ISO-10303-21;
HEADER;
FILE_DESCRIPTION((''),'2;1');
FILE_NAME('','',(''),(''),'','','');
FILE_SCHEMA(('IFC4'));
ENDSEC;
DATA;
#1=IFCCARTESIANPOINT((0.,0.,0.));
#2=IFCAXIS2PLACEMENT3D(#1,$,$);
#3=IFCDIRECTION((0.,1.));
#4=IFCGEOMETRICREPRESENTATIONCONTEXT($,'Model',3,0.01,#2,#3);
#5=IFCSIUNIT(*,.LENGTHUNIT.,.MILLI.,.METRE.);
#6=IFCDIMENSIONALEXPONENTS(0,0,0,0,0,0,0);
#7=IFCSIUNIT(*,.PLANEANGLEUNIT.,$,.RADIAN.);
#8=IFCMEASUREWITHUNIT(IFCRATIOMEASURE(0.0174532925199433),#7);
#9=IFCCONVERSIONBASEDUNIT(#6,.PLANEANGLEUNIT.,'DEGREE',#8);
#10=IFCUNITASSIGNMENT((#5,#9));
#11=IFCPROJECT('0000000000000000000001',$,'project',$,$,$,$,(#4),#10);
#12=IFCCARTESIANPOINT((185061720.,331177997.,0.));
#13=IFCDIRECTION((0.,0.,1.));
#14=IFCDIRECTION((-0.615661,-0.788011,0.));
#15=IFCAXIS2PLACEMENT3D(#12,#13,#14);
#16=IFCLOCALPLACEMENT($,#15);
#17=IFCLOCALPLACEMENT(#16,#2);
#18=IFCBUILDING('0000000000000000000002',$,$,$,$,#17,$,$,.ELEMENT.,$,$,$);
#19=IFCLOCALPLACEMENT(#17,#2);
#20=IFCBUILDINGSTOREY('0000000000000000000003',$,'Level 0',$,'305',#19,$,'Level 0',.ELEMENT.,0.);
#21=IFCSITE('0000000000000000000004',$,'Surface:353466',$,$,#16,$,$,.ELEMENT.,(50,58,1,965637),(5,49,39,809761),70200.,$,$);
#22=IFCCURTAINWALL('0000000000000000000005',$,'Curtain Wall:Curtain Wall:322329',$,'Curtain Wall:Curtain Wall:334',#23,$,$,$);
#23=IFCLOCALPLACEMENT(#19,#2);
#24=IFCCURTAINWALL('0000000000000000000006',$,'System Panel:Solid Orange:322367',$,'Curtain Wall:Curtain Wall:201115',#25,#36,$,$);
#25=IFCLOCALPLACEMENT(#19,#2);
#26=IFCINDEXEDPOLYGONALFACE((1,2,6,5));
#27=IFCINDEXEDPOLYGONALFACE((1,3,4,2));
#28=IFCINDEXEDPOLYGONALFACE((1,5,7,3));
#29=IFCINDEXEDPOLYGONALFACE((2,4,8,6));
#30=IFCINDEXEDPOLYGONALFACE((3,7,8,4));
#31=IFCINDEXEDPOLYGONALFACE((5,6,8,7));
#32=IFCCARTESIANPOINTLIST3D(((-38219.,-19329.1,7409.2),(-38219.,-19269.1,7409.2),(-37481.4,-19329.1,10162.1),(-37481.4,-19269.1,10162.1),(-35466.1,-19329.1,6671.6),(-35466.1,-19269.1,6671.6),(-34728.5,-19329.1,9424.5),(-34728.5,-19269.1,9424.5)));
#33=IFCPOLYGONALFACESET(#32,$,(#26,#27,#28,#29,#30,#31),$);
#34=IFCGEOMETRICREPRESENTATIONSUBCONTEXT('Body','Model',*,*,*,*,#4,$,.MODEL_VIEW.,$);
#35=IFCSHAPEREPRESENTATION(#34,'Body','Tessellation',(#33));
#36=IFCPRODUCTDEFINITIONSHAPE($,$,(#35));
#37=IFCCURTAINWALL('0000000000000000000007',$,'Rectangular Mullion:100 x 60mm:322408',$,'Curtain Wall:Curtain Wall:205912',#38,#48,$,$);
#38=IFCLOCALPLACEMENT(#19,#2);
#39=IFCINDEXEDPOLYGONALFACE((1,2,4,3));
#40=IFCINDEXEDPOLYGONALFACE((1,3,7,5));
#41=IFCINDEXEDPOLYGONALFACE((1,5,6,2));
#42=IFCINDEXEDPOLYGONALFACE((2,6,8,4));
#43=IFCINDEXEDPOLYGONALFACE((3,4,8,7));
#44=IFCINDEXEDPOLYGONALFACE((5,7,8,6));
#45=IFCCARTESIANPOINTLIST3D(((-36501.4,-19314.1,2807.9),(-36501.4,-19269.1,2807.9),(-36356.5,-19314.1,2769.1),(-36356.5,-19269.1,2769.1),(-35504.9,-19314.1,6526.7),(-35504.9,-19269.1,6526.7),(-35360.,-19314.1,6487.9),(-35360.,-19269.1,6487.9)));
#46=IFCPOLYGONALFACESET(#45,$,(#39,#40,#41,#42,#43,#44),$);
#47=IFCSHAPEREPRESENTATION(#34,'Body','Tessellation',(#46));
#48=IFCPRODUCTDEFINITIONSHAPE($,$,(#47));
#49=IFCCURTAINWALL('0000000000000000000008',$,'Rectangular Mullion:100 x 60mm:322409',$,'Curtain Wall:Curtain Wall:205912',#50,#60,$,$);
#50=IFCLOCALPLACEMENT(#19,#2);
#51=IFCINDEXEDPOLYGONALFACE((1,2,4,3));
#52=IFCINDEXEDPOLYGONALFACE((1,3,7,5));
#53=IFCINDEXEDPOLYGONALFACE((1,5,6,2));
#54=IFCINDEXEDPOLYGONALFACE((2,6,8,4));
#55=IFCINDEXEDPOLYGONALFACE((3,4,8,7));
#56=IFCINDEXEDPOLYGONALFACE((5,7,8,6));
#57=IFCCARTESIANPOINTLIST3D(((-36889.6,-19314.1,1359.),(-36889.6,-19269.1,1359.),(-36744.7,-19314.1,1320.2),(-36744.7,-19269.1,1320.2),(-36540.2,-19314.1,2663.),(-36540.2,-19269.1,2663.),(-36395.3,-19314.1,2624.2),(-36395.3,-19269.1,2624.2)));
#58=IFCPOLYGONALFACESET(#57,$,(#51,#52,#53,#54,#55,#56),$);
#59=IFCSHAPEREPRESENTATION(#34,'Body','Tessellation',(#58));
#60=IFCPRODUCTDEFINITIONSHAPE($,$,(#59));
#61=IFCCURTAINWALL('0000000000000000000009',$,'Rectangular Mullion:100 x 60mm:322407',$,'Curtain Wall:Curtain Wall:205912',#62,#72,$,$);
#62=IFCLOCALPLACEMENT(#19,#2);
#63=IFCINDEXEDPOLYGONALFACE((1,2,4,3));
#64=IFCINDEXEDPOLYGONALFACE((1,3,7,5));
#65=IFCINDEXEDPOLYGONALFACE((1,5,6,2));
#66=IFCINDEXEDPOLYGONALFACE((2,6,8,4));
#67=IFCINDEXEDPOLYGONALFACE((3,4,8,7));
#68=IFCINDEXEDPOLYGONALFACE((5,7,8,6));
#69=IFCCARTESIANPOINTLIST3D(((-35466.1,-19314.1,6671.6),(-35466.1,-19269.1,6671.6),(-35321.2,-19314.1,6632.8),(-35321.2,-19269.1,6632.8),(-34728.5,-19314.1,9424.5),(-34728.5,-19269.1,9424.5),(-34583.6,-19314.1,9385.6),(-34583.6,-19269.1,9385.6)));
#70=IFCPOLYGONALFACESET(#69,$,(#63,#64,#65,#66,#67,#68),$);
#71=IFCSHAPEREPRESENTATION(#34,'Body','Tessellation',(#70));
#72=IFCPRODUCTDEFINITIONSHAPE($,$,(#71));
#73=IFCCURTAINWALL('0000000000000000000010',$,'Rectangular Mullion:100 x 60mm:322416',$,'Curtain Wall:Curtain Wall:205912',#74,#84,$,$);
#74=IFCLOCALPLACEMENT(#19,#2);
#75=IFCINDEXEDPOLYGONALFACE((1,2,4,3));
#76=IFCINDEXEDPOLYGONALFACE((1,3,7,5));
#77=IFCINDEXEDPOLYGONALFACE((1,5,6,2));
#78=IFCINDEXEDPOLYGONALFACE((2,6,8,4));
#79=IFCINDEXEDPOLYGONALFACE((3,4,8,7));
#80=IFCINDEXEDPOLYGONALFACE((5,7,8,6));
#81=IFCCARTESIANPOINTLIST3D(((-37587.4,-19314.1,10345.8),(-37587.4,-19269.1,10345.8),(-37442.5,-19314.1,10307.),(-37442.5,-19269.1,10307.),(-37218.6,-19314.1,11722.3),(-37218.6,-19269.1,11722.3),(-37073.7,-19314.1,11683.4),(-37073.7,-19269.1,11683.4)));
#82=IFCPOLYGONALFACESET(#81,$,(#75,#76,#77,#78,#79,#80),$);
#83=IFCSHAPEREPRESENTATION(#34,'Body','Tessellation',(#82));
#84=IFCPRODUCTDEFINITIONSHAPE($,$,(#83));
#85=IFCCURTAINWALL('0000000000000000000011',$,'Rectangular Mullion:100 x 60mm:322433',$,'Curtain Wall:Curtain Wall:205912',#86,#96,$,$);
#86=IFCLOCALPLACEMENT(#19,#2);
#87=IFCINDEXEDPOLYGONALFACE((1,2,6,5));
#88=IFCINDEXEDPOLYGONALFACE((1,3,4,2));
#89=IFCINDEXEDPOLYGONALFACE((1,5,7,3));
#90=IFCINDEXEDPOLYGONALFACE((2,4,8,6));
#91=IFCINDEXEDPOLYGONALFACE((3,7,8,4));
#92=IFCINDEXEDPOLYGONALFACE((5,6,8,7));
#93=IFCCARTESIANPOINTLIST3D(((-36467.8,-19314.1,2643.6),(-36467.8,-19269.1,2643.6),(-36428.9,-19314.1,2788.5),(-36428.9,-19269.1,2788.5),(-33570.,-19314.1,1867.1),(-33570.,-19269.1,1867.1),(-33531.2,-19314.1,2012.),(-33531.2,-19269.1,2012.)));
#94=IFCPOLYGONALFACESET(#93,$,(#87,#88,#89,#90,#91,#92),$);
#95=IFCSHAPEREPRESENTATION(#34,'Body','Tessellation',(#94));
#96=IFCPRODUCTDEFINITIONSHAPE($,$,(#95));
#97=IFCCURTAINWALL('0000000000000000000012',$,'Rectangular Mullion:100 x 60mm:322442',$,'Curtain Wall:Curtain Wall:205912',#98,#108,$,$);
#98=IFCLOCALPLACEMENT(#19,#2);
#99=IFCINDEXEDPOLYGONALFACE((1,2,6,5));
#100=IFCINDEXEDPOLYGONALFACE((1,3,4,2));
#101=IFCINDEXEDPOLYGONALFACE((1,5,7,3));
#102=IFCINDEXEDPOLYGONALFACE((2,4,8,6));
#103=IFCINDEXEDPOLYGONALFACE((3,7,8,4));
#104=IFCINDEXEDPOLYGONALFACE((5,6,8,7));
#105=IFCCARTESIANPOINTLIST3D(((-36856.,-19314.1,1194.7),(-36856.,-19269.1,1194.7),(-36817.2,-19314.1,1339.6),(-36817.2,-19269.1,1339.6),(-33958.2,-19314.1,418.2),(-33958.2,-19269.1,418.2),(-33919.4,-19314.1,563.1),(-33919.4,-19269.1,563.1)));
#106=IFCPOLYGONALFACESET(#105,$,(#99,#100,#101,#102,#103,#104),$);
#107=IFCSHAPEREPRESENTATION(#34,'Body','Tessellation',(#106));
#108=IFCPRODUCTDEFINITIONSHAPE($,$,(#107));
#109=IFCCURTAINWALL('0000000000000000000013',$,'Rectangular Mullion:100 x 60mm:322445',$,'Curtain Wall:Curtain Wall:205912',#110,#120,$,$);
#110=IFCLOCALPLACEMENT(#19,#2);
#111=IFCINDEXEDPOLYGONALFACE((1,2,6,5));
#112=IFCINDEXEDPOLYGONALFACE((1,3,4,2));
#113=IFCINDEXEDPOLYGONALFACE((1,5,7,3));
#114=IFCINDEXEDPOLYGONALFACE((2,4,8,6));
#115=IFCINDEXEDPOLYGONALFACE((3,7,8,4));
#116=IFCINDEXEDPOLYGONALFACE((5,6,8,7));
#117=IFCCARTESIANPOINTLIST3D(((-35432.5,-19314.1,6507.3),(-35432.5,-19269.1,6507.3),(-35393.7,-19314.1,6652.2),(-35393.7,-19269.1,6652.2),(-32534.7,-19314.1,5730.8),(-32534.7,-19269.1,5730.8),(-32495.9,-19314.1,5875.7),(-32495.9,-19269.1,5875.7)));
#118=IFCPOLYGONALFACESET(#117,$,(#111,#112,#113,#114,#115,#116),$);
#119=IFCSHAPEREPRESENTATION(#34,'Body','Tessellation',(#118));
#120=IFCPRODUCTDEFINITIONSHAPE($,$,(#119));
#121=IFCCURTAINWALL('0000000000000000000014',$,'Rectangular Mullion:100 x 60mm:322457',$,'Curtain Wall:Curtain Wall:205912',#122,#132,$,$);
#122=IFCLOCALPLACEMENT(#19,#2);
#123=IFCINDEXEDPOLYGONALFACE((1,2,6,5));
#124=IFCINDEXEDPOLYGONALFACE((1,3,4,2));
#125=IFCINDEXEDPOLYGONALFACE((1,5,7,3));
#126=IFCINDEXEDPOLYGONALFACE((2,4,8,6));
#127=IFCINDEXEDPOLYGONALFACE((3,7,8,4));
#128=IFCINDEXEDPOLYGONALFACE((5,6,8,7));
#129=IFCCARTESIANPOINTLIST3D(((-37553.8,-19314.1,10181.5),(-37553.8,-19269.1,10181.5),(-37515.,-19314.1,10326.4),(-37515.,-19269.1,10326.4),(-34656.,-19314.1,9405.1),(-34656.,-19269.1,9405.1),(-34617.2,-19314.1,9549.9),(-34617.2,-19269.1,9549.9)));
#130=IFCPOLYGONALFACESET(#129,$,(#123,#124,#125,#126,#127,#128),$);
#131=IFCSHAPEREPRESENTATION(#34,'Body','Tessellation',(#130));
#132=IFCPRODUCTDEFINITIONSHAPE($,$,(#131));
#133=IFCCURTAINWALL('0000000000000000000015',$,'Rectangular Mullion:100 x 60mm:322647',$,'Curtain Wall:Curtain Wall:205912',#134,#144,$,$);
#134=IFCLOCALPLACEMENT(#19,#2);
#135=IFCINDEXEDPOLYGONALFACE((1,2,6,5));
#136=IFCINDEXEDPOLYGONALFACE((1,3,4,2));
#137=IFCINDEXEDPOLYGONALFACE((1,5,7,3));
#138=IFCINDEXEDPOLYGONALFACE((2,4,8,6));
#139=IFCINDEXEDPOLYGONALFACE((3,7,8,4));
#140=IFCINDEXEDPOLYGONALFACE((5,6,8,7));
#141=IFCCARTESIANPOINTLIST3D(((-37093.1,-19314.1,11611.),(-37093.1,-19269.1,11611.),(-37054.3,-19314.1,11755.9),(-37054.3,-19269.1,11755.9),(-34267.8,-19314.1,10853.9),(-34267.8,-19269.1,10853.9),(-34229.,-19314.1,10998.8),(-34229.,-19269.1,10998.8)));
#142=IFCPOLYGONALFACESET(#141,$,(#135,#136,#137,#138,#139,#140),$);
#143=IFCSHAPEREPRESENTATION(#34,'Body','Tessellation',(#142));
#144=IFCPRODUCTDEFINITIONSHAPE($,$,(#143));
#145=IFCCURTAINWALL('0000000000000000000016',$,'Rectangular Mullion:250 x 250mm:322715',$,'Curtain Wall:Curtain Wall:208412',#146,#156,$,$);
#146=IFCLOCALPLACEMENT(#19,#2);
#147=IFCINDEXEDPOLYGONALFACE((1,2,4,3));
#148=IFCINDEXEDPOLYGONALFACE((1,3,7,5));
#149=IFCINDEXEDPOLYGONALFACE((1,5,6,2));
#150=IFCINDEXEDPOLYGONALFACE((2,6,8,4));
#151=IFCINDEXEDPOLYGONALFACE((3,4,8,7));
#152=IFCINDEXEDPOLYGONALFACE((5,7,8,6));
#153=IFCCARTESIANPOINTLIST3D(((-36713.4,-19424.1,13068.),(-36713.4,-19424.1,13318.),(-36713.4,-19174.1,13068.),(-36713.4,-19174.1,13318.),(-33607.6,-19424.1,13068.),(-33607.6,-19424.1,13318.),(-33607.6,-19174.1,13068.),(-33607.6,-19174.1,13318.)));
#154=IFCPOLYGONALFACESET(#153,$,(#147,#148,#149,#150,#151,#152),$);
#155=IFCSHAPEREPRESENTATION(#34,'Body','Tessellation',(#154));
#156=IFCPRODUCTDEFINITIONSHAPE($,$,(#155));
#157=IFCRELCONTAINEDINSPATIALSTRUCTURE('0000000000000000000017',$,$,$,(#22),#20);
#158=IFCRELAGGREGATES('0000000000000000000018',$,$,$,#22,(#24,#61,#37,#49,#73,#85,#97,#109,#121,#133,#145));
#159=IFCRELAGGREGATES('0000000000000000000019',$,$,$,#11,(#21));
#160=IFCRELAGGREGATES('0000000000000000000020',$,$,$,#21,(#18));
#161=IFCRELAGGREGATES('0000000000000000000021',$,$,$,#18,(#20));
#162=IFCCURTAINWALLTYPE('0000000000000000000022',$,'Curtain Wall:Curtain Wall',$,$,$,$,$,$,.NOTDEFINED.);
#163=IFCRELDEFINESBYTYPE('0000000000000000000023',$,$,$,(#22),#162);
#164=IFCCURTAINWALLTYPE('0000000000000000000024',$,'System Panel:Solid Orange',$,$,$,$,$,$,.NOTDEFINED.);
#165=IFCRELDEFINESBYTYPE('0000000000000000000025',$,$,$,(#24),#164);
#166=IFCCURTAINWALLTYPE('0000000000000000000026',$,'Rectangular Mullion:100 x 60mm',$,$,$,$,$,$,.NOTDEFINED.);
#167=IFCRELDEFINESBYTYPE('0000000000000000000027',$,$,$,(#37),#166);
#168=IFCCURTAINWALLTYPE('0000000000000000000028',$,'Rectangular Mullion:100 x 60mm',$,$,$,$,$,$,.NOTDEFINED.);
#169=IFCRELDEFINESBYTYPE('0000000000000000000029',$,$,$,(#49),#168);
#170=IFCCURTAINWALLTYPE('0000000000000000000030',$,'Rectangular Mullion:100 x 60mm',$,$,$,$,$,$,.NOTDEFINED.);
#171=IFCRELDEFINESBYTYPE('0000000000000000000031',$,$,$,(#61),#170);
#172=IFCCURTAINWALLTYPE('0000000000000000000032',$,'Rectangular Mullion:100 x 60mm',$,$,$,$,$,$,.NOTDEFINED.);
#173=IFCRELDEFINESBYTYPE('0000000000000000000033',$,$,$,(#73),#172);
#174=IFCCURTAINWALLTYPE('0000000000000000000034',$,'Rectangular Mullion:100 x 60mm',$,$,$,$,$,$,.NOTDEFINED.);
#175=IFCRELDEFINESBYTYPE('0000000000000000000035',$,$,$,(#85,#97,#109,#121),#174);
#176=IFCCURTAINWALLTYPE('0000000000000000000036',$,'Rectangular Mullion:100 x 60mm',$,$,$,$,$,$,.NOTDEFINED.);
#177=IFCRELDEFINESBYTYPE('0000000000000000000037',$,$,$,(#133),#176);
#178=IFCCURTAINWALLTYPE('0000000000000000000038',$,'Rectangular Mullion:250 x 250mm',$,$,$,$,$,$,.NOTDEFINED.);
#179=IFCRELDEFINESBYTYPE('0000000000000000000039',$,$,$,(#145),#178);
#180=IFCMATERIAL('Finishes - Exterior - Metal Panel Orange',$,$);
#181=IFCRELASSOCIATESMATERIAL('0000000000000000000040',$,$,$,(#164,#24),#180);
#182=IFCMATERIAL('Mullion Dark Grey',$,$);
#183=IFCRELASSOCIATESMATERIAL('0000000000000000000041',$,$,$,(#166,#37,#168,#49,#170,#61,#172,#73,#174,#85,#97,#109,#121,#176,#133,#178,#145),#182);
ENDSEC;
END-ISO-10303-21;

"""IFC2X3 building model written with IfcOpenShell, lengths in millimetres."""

from ifc_helpers import new_model, entity, si_unit, converted_unit, direction, frame, frame_2d, origin, origin_2d_with_axis, place, context, subcontext, project, spatial, rectangle, extrude, source, transform, mapped, material, type_object, type_shapes, element, aggregate, save


model = new_model("IFC2X3")

# Units and contexts
model_context = context("Model", 3, precision=0.01, world=origin(), true_north=direction((0.0, 1.0)))
body_context = subcontext(model_context, "Body", "Model", "MODEL_VIEW")
ifc_project = project(units=[si_unit("LENGTHUNIT", "METRE", prefix="MILLI"), converted_unit("PLANEANGLEUNIT", "DEGREE", entity("IfcRatioMeasure", 0.0174532925199433), si_unit("PLANEANGLEUNIT", "RADIAN"), dimensions=[0, 0, 0, 0, 0, 0, 0])], contexts=[model_context])

# Site, building, storey
site_placement = place(None, frame((185061720.0, 331177997.0, 0.0), z_axis=(0.0, 0.0, 1.0), x_axis=(-0.615661, -0.788011, 0.0)))
site = spatial("IfcSite", under=ifc_project, at=site_placement, Name="Surface:353466", CompositionType="ELEMENT", RefLatitude=(50, 58, 1, 965637), RefLongitude=(5, 49, 39, 809761), RefElevation=70200.0)
building_placement = place(site_placement, origin())
building = spatial("IfcBuilding", under=site, at=building_placement, CompositionType="ELEMENT")
storey_placement = place(building_placement, origin())
storey = spatial("IfcBuildingStorey", under=building, at=storey_placement, Name="Level 0", ObjectType="305", LongName="Level 0", CompositionType="ELEMENT", Elevation=0.0)

# Curtain walls
curtain_wall_type_1 = type_object("IfcCurtainWallType", Name="Curtain Wall:Curtain Wall", PredefinedType="NOTDEFINED")
curtain_wall_1_placement = place(storey_placement, origin())
curtain_wall_1 = element("IfcCurtainWall", 1, at=curtain_wall_1_placement, inside=storey, type_object=curtain_wall_type_1, Name="Curtain Wall:Curtain Wall:322329", ObjectType="Curtain Wall:Curtain Wall:334")
ifc_material_1 = material(Name="Finishes - Exterior - Metal Panel Orange")
curtain_wall_type_2 = type_object("IfcCurtainWallType", Name="System Panel:Solid Orange", PredefinedType="NOTDEFINED", material=ifc_material_1)
shared_shape_1 = source(origin(), body_context, "Body", "SweptSolid", [
    extrude(rectangle(XDim=60.0, YDim=2850.0, at=frame_2d((0.0, 0.0), x_axis=(1.0, 0.0))), frame((0.0, 0.0, 0.0), z_axis=(0.0, 0.0, 1.0), x_axis=(0.0, 1.0, 0.0)), (0.0, 0.0, 1.0), 2850.0),
])
type_shapes(curtain_wall_type_2, [shared_shape_1])
curtain_wall_2_placement = place(storey_placement, frame((-36842.6, -19299.1, 7040.4), z_axis=(0.258819, 0.0, 0.965926), x_axis=(-0.965926, 0.0, 0.258819)))
curtain_wall_2 = element("IfcCurtainWall", 2, at=curtain_wall_2_placement, type_object=curtain_wall_type_2, material=ifc_material_1, Name="System Panel:Solid Orange:322367", ObjectType="Curtain Wall:Curtain Wall:201115", context=body_context, shape_type="MappedRepresentation", body=[
    mapped(shared_shape_1, transform((0.0, 0.0, 0.0), scale=1.0)),
])
ifc_material_2 = material(Name="Mullion Dark Grey")
curtain_wall_type_3 = type_object("IfcCurtainWallType", Name="Rectangular Mullion:100 x 60mm", PredefinedType="NOTDEFINED", material=ifc_material_2)
shared_shape_2 = source(origin(), body_context, "Body", "SweptSolid", [
    extrude(rectangle(XDim=45.0, YDim=150.0, at=frame_2d((0.0, 0.0), x_axis=(1.0, 0.0))), frame((0.0, 7.5, -3850.0), z_axis=(0.0, 0.0, 1.0), x_axis=(0.0, -1.0, 0.0)), (0.0, 0.0, 1.0), 3850.0),
])
type_shapes(curtain_wall_type_3, [shared_shape_2])
curtain_wall_3_placement = place(storey_placement, frame((-36428.9, -19299.1, 2788.5), z_axis=(-0.258819, 0.0, -0.965926), x_axis=(-0.965926, 0.0, 0.258819)))
curtain_wall_3 = element("IfcCurtainWall", 3, at=curtain_wall_3_placement, type_object=curtain_wall_type_3, material=ifc_material_2, Name="Rectangular Mullion:100 x 60mm:322408", ObjectType="Curtain Wall:Curtain Wall:205912", context=body_context, shape_type="MappedRepresentation", body=[
    mapped(shared_shape_2, transform((0.0, 0.0, 0.0), scale=1.0)),
])
curtain_wall_type_4 = type_object("IfcCurtainWallType", Name="Rectangular Mullion:100 x 60mm", PredefinedType="NOTDEFINED", material=ifc_material_2)
shared_shape_3 = source(origin(), body_context, "Body", "SweptSolid", [
    extrude(rectangle(XDim=45.0, YDim=150.0, at=frame_2d((0.0, 0.0), x_axis=(1.0, 0.0))), frame((0.0, 7.5, -1350.0), z_axis=(0.0, 0.0, 1.0), x_axis=(0.0, -1.0, 0.0)), (0.0, 0.0, 1.0), 1350.0),
])
type_shapes(curtain_wall_type_4, [shared_shape_3])
curtain_wall_4_placement = place(storey_placement, frame((-36817.2, -19299.1, 1339.6), z_axis=(-0.258819, 0.0, -0.965926), x_axis=(-0.965926, 0.0, 0.258819)))
curtain_wall_4 = element("IfcCurtainWall", 4, at=curtain_wall_4_placement, type_object=curtain_wall_type_4, material=ifc_material_2, Name="Rectangular Mullion:100 x 60mm:322409", ObjectType="Curtain Wall:Curtain Wall:205912", context=body_context, shape_type="MappedRepresentation", body=[
    mapped(shared_shape_3, transform((0.0, 0.0, 0.0), scale=1.0)),
])
curtain_wall_type_5 = type_object("IfcCurtainWallType", Name="Rectangular Mullion:100 x 60mm", PredefinedType="NOTDEFINED", material=ifc_material_2)
shared_shape_4 = source(origin(), body_context, "Body", "SweptSolid", [
    extrude(rectangle(XDim=45.0, YDim=150.0, at=frame_2d((0.0, 0.0), x_axis=(1.0, 0.0))), frame((0.0, 7.5, -2850.0), z_axis=(0.0, 0.0, 1.0), x_axis=(0.0, -1.0, 0.0)), (0.0, 0.0, 1.0), 2850.0),
])
type_shapes(curtain_wall_type_5, [shared_shape_4])
curtain_wall_5_placement = place(storey_placement, frame((-35393.7, -19299.1, 6652.2), z_axis=(-0.258819, 0.0, -0.965926), x_axis=(-0.965926, 0.0, 0.258819)))
curtain_wall_5 = element("IfcCurtainWall", 5, at=curtain_wall_5_placement, type_object=curtain_wall_type_5, material=ifc_material_2, Name="Rectangular Mullion:100 x 60mm:322407", ObjectType="Curtain Wall:Curtain Wall:205912", context=body_context, shape_type="MappedRepresentation", body=[
    mapped(shared_shape_4, transform((0.0, 0.0, 0.0), scale=1.0)),
])
curtain_wall_type_6 = type_object("IfcCurtainWallType", Name="Rectangular Mullion:100 x 60mm", PredefinedType="NOTDEFINED", material=ifc_material_2)
shared_shape_5 = source(origin(), body_context, "Body", "SweptSolid", [
    extrude(rectangle(XDim=45.0, YDim=150.0, at=frame_2d((0.0, 0.0), x_axis=(1.0, 0.0))), frame((0.0, 7.5, -1425.0), z_axis=(0.0, 0.0, 1.0), x_axis=(0.0, -1.0, 0.0)), (0.0, 0.0, 1.0), 1425.0),
])
type_shapes(curtain_wall_type_6, [shared_shape_5])
curtain_wall_6_placement = place(storey_placement, frame((-37515.0, -19299.1, 10326.4), z_axis=(-0.258819, 0.0, -0.965926), x_axis=(-0.965926, 0.0, 0.258819)))
curtain_wall_6 = element("IfcCurtainWall", 6, at=curtain_wall_6_placement, type_object=curtain_wall_type_6, material=ifc_material_2, Name="Rectangular Mullion:100 x 60mm:322416", ObjectType="Curtain Wall:Curtain Wall:205912", context=body_context, shape_type="MappedRepresentation", body=[
    mapped(shared_shape_5, transform((0.0, 0.0, 0.0), scale=1.0)),
])
curtain_wall_type_7 = type_object("IfcCurtainWallType", Name="Rectangular Mullion:100 x 60mm", PredefinedType="NOTDEFINED", material=ifc_material_2)
shared_shape_6 = source(origin(), body_context, "Body", "SweptSolid", [
    extrude(rectangle(XDim=45.0, YDim=150.0, at=frame_2d((0.0, 0.0), x_axis=(1.0, 0.0))), frame((0.0, 7.5, -3000.0), z_axis=(0.0, 0.0, 1.0), x_axis=(0.0, -1.0, 0.0)), (0.0, 0.0, 1.0), 3000.0),
])
type_shapes(curtain_wall_type_7, [shared_shape_6])
curtain_wall_7_placement = place(storey_placement, frame((-36448.4, -19299.1, 2716.0), z_axis=(-0.965926, 0.0, 0.258819), x_axis=(0.258819, 0.0, 0.965926)))
curtain_wall_7 = element("IfcCurtainWall", 7, at=curtain_wall_7_placement, type_object=curtain_wall_type_7, material=ifc_material_2, Name="Rectangular Mullion:100 x 60mm:322433", ObjectType="Curtain Wall:Curtain Wall:205912", context=body_context, shape_type="MappedRepresentation", body=[
    mapped(shared_shape_6, transform((0.0, 0.0, 0.0), scale=1.0)),
])
curtain_wall_8_placement = place(storey_placement, frame((-36836.6, -19299.1, 1267.1), z_axis=(-0.965926, 0.0, 0.258819), x_axis=(0.258819, 0.0, 0.965926)))
curtain_wall_8 = element("IfcCurtainWall", 8, at=curtain_wall_8_placement, type_object=curtain_wall_type_7, material=ifc_material_2, Name="Rectangular Mullion:100 x 60mm:322442", ObjectType="Curtain Wall:Curtain Wall:205912", context=body_context, shape_type="MappedRepresentation", body=[
    mapped(shared_shape_6, transform((0.0, 0.0, 0.0), scale=1.0)),
])
curtain_wall_9_placement = place(storey_placement, frame((-35413.1, -19299.1, 6579.7), z_axis=(-0.965926, 0.0, 0.258819), x_axis=(0.258819, 0.0, 0.965926)))
curtain_wall_9 = element("IfcCurtainWall", 9, at=curtain_wall_9_placement, type_object=curtain_wall_type_7, material=ifc_material_2, Name="Rectangular Mullion:100 x 60mm:322445", ObjectType="Curtain Wall:Curtain Wall:205912", context=body_context, shape_type="MappedRepresentation", body=[
    mapped(shared_shape_6, transform((0.0, 0.0, 0.0), scale=1.0)),
])
curtain_wall_10_placement = place(storey_placement, frame((-37534.4, -19299.1, 10254.0), z_axis=(-0.965926, 0.0, 0.258819), x_axis=(0.258819, 0.0, 0.965926)))
curtain_wall_10 = element("IfcCurtainWall", 10, at=curtain_wall_10_placement, type_object=curtain_wall_type_7, material=ifc_material_2, Name="Rectangular Mullion:100 x 60mm:322457", ObjectType="Curtain Wall:Curtain Wall:205912", context=body_context, shape_type="MappedRepresentation", body=[
    mapped(shared_shape_6, transform((0.0, 0.0, 0.0), scale=1.0)),
])
curtain_wall_type_8 = type_object("IfcCurtainWallType", Name="Rectangular Mullion:100 x 60mm", PredefinedType="NOTDEFINED", material=ifc_material_2)
shared_shape_7 = source(origin(), body_context, "Body", "SweptSolid", [
    extrude(rectangle(XDim=45.0, YDim=150.0, at=frame_2d((0.0, 0.0), x_axis=(1.0, 0.0))), frame((0.0, 7.5, -2925.0), z_axis=(0.0, 0.0, 1.0), x_axis=(0.0, -1.0, 0.0)), (0.0, 0.0, 1.0), 2925.0),
])
type_shapes(curtain_wall_type_8, [shared_shape_7])
curtain_wall_11_placement = place(storey_placement, frame((-37073.7, -19299.1, 11683.4), z_axis=(-0.965926, 0.0, 0.258819), x_axis=(0.258819, 0.0, 0.965926)))
curtain_wall_11 = element("IfcCurtainWall", 11, at=curtain_wall_11_placement, type_object=curtain_wall_type_8, material=ifc_material_2, Name="Rectangular Mullion:100 x 60mm:322647", ObjectType="Curtain Wall:Curtain Wall:205912", context=body_context, shape_type="MappedRepresentation", body=[
    mapped(shared_shape_7, transform((0.0, 0.0, 0.0), scale=1.0)),
])
curtain_wall_type_9 = type_object("IfcCurtainWallType", Name="Rectangular Mullion:250 x 250mm", PredefinedType="NOTDEFINED", material=ifc_material_2)
shared_shape_8 = source(origin(), body_context, "Body", "SweptSolid", [
    extrude(rectangle(XDim=250.0, YDim=250.0, at=origin_2d_with_axis()), frame((-125.0, 0.0, -3105.8), z_axis=(0.0, 0.0, 1.0), x_axis=(-1.0, 0.0, 0.0)), (0.0, 0.0, 1.0), 3105.8),
])
type_shapes(curtain_wall_type_9, [shared_shape_8])
curtain_wall_12_placement = place(storey_placement, frame((-36713.4, -19299.1, 13318.0), z_axis=(-1.0, 0.0, 0.0), x_axis=(0.0, 0.0, 1.0)))
curtain_wall_12 = element("IfcCurtainWall", 12, at=curtain_wall_12_placement, type_object=curtain_wall_type_9, material=ifc_material_2, Name="Rectangular Mullion:250 x 250mm:322715", ObjectType="Curtain Wall:Curtain Wall:208412", context=body_context, shape_type="MappedRepresentation", body=[
    mapped(shared_shape_8, transform((0.0, 0.0, 0.0), scale=1.0)),
])
aggregate(curtain_wall_1, [curtain_wall_2, curtain_wall_5, curtain_wall_3, curtain_wall_4, curtain_wall_6, curtain_wall_7, curtain_wall_8, curtain_wall_9, curtain_wall_10, curtain_wall_11, curtain_wall_12])

save(model, "model.ifc")
